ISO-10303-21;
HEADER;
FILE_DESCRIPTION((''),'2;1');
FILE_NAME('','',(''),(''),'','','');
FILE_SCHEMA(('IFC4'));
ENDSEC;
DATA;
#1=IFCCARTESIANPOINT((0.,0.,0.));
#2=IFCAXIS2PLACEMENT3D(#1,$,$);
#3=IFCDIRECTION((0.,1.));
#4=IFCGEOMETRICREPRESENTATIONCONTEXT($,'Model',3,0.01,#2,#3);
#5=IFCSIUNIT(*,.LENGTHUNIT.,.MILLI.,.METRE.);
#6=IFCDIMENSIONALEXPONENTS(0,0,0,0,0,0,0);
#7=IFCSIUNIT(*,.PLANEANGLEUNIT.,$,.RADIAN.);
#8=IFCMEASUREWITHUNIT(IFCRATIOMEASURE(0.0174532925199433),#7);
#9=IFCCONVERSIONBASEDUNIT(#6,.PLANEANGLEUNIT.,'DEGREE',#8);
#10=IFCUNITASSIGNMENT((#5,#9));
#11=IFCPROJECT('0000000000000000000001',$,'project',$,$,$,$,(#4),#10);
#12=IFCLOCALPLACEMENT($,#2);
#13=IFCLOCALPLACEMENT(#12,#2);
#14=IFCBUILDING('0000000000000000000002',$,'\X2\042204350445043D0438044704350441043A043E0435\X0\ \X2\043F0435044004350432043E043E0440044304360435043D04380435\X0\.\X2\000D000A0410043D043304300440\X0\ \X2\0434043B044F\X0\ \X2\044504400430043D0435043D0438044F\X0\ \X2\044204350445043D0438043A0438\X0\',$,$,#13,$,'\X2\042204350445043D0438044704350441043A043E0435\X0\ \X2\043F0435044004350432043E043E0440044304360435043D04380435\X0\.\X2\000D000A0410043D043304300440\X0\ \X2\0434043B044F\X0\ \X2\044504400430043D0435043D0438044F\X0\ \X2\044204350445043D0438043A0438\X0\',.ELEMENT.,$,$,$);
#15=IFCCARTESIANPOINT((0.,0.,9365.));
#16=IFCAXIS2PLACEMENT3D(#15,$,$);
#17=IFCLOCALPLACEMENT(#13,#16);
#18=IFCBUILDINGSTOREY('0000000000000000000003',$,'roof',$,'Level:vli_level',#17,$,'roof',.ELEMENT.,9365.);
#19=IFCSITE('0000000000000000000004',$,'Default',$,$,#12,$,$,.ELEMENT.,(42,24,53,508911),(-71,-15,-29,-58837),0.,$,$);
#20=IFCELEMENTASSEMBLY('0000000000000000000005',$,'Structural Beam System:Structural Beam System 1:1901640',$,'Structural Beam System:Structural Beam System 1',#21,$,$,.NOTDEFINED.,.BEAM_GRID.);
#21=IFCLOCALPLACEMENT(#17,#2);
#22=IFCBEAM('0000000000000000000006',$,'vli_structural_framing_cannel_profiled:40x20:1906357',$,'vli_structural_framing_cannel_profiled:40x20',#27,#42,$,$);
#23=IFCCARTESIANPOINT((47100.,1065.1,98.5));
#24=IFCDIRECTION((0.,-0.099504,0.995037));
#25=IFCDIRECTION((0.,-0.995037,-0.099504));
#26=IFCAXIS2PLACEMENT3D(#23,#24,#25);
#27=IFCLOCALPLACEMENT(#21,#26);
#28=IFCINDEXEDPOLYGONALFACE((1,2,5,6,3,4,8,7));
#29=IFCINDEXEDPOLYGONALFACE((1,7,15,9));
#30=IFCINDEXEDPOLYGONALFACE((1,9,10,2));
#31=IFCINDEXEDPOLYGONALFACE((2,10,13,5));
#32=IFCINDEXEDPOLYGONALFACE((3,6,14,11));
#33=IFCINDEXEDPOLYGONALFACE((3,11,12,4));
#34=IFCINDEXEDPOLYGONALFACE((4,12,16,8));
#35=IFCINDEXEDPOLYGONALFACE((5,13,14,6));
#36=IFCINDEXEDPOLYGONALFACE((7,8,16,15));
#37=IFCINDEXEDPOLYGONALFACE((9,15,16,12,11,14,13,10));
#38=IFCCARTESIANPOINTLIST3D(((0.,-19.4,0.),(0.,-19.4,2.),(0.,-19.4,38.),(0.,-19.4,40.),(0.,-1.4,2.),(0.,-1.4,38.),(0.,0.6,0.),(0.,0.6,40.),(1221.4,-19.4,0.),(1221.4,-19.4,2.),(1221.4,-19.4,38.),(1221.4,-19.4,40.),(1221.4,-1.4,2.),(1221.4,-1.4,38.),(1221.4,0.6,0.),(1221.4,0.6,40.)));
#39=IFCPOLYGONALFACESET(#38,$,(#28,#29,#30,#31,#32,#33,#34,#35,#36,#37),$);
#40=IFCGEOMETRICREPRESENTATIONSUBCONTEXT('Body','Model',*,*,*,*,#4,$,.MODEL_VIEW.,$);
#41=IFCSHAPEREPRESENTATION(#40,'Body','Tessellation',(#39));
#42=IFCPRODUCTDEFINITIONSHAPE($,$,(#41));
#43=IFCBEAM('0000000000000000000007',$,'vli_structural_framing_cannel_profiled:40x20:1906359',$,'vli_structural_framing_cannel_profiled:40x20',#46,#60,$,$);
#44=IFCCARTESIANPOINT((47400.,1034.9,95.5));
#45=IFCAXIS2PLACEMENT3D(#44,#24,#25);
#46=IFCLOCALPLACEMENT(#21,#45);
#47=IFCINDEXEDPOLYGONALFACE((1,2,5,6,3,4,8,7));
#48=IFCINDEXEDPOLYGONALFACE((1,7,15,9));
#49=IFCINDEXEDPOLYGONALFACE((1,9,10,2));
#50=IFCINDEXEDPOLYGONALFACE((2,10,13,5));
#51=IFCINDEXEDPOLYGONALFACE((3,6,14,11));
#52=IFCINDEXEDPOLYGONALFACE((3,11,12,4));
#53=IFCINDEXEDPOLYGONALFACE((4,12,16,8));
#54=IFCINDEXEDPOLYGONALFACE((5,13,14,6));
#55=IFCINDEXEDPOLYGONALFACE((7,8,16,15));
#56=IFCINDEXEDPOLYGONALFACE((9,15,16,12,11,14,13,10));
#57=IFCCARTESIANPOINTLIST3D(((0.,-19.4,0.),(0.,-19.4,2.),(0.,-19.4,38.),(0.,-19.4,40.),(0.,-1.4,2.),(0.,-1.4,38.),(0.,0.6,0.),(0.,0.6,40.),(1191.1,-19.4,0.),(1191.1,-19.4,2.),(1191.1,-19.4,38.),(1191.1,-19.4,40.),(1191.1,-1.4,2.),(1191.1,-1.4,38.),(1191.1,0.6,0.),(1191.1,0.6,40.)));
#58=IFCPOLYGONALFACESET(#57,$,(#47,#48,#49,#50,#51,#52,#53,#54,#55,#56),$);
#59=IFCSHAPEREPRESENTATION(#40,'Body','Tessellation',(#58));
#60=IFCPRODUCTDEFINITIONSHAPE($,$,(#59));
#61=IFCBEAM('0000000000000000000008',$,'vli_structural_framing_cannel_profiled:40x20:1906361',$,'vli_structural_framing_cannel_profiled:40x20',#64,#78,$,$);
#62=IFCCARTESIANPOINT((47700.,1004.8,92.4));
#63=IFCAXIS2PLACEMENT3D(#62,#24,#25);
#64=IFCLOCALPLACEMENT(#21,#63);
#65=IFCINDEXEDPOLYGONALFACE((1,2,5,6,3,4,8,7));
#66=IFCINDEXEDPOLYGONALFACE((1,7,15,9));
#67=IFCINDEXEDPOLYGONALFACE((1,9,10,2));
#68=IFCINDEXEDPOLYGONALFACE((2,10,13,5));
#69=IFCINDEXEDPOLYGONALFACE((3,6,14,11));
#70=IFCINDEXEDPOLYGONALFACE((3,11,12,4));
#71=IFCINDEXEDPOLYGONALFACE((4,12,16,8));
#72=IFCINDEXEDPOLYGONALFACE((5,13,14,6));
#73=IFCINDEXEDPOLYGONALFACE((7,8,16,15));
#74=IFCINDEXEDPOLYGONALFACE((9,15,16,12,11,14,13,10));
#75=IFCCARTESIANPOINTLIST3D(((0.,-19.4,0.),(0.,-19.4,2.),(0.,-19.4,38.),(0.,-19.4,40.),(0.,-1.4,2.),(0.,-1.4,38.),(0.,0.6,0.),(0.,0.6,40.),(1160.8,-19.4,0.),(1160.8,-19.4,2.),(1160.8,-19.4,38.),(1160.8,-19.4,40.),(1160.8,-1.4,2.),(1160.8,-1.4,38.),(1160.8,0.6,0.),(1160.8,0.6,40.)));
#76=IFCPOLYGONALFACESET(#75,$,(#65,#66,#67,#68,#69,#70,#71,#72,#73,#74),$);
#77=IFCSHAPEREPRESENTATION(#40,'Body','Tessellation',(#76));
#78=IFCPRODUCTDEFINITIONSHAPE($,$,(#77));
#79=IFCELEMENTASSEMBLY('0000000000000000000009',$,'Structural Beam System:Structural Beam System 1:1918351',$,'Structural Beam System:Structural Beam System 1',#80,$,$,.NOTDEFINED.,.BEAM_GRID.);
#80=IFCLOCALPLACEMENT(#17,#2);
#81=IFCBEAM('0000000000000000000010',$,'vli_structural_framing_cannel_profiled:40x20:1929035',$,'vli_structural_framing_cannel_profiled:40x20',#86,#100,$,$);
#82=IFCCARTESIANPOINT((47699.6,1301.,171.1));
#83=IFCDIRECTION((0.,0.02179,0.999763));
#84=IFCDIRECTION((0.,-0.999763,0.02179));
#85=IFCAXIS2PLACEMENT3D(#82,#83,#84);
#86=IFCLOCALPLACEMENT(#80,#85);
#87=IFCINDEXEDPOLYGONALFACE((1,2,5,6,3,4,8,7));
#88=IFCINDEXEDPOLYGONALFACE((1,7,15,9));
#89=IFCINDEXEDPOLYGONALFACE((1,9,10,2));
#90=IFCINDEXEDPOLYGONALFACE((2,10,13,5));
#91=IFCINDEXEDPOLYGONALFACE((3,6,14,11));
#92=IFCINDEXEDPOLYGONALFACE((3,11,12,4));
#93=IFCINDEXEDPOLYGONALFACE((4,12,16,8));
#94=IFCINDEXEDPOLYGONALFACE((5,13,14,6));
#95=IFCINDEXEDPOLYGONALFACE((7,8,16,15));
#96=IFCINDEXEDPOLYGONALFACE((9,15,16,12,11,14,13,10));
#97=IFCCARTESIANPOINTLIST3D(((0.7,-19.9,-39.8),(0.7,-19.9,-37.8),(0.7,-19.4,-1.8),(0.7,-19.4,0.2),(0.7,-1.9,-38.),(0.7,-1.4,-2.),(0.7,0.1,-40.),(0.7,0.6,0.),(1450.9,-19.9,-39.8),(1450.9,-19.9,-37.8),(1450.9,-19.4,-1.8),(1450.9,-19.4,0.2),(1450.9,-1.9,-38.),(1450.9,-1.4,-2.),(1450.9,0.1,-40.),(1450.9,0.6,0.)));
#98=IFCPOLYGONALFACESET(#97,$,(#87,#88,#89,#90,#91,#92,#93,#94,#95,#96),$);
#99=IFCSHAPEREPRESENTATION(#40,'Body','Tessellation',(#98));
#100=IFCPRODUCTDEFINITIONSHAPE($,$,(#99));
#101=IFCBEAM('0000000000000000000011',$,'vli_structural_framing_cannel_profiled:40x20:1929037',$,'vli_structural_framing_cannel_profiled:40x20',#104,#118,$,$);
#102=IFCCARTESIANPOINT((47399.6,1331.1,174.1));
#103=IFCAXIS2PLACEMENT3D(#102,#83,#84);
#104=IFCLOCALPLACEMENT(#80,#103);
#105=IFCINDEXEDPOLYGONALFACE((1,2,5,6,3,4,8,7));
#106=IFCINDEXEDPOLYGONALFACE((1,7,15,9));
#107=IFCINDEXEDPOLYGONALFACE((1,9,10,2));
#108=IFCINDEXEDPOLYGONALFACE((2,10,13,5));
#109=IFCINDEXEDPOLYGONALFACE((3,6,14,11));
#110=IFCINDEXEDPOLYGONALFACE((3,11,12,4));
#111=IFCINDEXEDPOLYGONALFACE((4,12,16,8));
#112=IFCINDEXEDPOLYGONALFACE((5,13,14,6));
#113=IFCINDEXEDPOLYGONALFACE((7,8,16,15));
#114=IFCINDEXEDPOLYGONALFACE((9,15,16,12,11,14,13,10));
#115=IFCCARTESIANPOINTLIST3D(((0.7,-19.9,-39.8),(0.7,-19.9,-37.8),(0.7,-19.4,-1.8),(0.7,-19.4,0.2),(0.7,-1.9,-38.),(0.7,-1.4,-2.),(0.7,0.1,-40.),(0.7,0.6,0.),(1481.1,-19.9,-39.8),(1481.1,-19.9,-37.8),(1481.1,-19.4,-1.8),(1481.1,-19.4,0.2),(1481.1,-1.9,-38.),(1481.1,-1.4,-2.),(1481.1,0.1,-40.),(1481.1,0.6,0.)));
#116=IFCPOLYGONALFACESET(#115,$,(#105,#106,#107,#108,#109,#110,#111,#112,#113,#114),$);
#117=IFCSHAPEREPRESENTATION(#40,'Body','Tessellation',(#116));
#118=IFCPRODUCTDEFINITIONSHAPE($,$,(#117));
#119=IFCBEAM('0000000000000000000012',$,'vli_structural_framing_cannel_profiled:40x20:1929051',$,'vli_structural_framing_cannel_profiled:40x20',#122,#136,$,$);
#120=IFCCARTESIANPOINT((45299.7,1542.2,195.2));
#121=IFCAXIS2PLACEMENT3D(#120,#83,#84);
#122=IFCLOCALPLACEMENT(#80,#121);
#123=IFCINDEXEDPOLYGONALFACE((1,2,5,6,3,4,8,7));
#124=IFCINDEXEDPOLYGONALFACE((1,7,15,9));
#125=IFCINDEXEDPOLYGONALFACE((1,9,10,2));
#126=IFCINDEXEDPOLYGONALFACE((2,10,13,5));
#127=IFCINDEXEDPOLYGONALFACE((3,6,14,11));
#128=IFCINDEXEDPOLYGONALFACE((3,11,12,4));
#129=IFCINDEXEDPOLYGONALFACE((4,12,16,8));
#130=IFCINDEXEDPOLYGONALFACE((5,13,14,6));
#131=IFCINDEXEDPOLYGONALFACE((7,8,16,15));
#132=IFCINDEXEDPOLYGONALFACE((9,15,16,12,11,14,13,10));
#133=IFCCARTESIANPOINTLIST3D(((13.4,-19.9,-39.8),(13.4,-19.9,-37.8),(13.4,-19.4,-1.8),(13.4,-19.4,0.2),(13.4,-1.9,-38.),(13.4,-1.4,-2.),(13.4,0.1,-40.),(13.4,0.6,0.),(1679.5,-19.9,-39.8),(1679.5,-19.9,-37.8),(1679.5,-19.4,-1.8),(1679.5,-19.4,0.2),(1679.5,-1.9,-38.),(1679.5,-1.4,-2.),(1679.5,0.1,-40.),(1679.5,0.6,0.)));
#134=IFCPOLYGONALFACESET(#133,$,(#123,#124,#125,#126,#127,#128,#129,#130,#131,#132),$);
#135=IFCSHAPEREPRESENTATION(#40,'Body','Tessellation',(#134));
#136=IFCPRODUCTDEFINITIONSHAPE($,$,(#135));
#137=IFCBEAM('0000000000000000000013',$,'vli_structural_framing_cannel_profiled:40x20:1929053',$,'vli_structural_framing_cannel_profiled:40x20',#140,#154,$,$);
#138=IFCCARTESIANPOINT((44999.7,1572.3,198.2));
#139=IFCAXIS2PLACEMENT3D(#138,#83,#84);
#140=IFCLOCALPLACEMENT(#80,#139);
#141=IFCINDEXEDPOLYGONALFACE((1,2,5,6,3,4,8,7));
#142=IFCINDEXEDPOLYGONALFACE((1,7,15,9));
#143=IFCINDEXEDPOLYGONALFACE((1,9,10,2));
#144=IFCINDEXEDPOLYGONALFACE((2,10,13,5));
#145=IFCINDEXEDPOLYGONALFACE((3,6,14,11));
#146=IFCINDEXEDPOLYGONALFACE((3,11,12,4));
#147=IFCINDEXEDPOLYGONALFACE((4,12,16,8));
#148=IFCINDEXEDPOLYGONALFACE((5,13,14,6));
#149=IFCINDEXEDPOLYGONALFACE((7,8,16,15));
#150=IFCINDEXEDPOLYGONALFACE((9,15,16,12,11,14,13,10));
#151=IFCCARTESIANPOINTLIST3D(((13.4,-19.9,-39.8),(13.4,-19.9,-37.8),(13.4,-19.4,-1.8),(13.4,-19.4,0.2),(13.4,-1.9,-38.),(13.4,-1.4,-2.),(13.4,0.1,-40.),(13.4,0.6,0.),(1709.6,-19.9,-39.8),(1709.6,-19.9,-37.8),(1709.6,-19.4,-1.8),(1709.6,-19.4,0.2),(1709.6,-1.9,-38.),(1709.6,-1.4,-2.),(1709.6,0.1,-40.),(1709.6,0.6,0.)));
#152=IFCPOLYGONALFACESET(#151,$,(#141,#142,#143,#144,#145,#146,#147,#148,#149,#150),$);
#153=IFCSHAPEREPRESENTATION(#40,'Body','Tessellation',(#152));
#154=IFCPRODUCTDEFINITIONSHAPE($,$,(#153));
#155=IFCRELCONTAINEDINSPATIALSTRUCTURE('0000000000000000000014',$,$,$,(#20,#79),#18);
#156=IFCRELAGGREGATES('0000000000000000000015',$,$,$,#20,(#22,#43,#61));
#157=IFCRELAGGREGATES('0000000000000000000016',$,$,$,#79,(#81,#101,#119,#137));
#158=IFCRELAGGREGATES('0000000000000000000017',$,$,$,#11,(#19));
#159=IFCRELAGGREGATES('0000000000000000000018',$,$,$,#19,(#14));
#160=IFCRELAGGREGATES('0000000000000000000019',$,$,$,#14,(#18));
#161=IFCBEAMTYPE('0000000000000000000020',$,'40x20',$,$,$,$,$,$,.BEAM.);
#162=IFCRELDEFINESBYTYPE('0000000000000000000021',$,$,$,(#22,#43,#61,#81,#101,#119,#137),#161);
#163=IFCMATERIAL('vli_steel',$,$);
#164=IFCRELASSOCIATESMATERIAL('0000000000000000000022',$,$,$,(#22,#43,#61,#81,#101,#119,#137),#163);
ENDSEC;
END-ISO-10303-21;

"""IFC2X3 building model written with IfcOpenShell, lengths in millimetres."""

from ifc_helpers import new_model, entity, si_unit, converted_unit, direction, frame, origin, place, context, subcontext, project, spatial, polyline, outline, extrude, material, type_object, element, aggregate, save


model = new_model("IFC2X3")

# Units and contexts
model_context = context("Model", 3, precision=0.01, world=origin(), true_north=direction((0.0, 1.0)))
body_context = subcontext(model_context, "Body", "Model", "MODEL_VIEW")
ifc_project = project(units=[si_unit("LENGTHUNIT", "METRE", prefix="MILLI"), converted_unit("PLANEANGLEUNIT", "DEGREE", entity("IfcRatioMeasure", 0.0174532925199433), si_unit("PLANEANGLEUNIT", "RADIAN"), dimensions=[0, 0, 0, 0, 0, 0, 0])], contexts=[model_context])

# Site, building, storey
site_placement = place(None, origin())
site = spatial("IfcSite", under=ifc_project, at=site_placement, Name="Default", CompositionType="ELEMENT", RefLatitude=(42, 24, 53, 508911), RefLongitude=(-71, -15, -29, -58837), RefElevation=0.0)
building_placement = place(site_placement, origin())
building = spatial("IfcBuilding", under=site, at=building_placement, Name="Техническое перевооружение.\r\nАнгар для хранения техники", LongName="Техническое перевооружение.\r\nАнгар для хранения техники", CompositionType="ELEMENT")
storey_placement = place(building_placement, frame((0.0, 0.0, 9365.0)))
storey = spatial("IfcBuildingStorey", under=building, at=storey_placement, Name="roof", ObjectType="Level:vli_level", LongName="roof", CompositionType="ELEMENT", Elevation=9365.0)

# Element assemblies, beams
assembly_1_placement = place(storey_placement, origin())
assembly_1 = element("IfcElementAssembly", 1, at=assembly_1_placement, inside=storey, Name="Structural Beam System:Structural Beam System 1:1901640", ObjectType="Structural Beam System:Structural Beam System 1", AssemblyPlace="NOTDEFINED", PredefinedType="BEAM_GRID")
ifc_material = material(Name="vli_steel")
beam_type = type_object("IfcBeamType", Name="40x20", PredefinedType="BEAM")
beam_1_placement = place(assembly_1_placement, frame((47100.0, 1065.1, 98.5), z_axis=(0.0, -0.099504, 0.995037), x_axis=(0.0, -0.995037, -0.099504)))
beam_1 = element("IfcBeam", 2, at=beam_1_placement, type_object=beam_type, material=ifc_material, Name="vli_structural_framing_cannel_profiled:40x20:1906357", ObjectType="vli_structural_framing_cannel_profiled:40x20", context=body_context, shape_type="SweptSolid", body=[
    extrude(outline(polyline([(-20.0, -9.5), (-18.0, -9.5), (-18.0, 8.5), (18.0, 8.5), (18.0, -9.5), (20.0, -9.5), (20.0, 10.5), (-20.0, 10.5), (-20.0, -9.5)])), frame((0.0, -9.9, 20.0), z_axis=(1.0, 0.0, 0.0), x_axis=(0.0, 0.0, -1.0)), (0.0, 0.0, 1.0), 1221.4),
])
beam_2_placement = place(assembly_1_placement, frame((47400.0, 1034.9, 95.5), z_axis=(0.0, -0.099504, 0.995037), x_axis=(0.0, -0.995037, -0.099504)))
beam_2 = element("IfcBeam", 3, at=beam_2_placement, type_object=beam_type, material=ifc_material, Name="vli_structural_framing_cannel_profiled:40x20:1906359", ObjectType="vli_structural_framing_cannel_profiled:40x20", context=body_context, shape_type="SweptSolid", body=[
    extrude(outline(polyline([(-20.0, -9.5), (-18.0, -9.5), (-18.0, 8.5), (18.0, 8.5), (18.0, -9.5), (20.0, -9.5), (20.0, 10.5), (-20.0, 10.5), (-20.0, -9.5)])), frame((0.0, -9.9, 20.0), z_axis=(1.0, 0.0, 0.0), x_axis=(0.0, 0.0, -1.0)), (0.0, 0.0, 1.0), 1191.1),
])
beam_3_placement = place(assembly_1_placement, frame((47700.0, 1004.8, 92.4), z_axis=(0.0, -0.099504, 0.995037), x_axis=(0.0, -0.995037, -0.099504)))
beam_3 = element("IfcBeam", 4, at=beam_3_placement, type_object=beam_type, material=ifc_material, Name="vli_structural_framing_cannel_profiled:40x20:1906361", ObjectType="vli_structural_framing_cannel_profiled:40x20", context=body_context, shape_type="SweptSolid", body=[
    extrude(outline(polyline([(-20.0, -9.5), (-18.0, -9.5), (-18.0, 8.5), (18.0, 8.5), (18.0, -9.5), (20.0, -9.5), (20.0, 10.5), (-20.0, 10.5), (-20.0, -9.5)])), frame((0.0, -9.9, 20.0), z_axis=(1.0, 0.0, 0.0), x_axis=(0.0, 0.0, -1.0)), (0.0, 0.0, 1.0), 1160.8),
])
aggregate(assembly_1, [beam_1, beam_2, beam_3])
assembly_2_placement = place(storey_placement, origin())
assembly_2 = element("IfcElementAssembly", 5, at=assembly_2_placement, inside=storey, Name="Structural Beam System:Structural Beam System 1:1918351", ObjectType="Structural Beam System:Structural Beam System 1", AssemblyPlace="NOTDEFINED", PredefinedType="BEAM_GRID")
beam_4_placement = place(assembly_2_placement, frame((47699.6, 1301.0, 171.1), z_axis=(0.0, 0.02179, 0.999763), x_axis=(0.0, -0.999763, 0.02179)))
beam_4 = element("IfcBeam", 6, at=beam_4_placement, type_object=beam_type, material=ifc_material, Name="vli_structural_framing_cannel_profiled:40x20:1929035", ObjectType="vli_structural_framing_cannel_profiled:40x20", context=body_context, shape_type="SweptSolid", body=[
    extrude(outline(polyline([(-10.5, -20.0), (9.5, -20.0), (9.5, -18.0), (-8.5, -18.0), (-8.5, 18.0), (9.5, 18.0), (9.5, 20.0), (-10.5, 20.0), (-10.5, -20.0)])), frame((0.7, -10.1, -19.9), z_axis=(1.0, 0.0, 0.0), x_axis=(0.0, -0.999925, 0.012243)), (0.0, 0.0, 1.0), 1450.2),
])
beam_5_placement = place(assembly_2_placement, frame((47399.6, 1331.1, 174.1), z_axis=(0.0, 0.02179, 0.999763), x_axis=(0.0, -0.999763, 0.02179)))
beam_5 = element("IfcBeam", 7, at=beam_5_placement, type_object=beam_type, material=ifc_material, Name="vli_structural_framing_cannel_profiled:40x20:1929037", ObjectType="vli_structural_framing_cannel_profiled:40x20", context=body_context, shape_type="SweptSolid", body=[
    extrude(outline(polyline([(-10.5, -20.0), (9.5, -20.0), (9.5, -18.0), (-8.5, -18.0), (-8.5, 18.0), (9.5, 18.0), (9.5, 20.0), (-10.5, 20.0), (-10.5, -20.0)])), frame((0.7, -10.1, -19.9), z_axis=(1.0, 0.0, 0.0), x_axis=(0.0, -0.999925, 0.012243)), (0.0, 0.0, 1.0), 1480.4),
])
beam_6_placement = place(assembly_2_placement, frame((45299.7, 1542.2, 195.2), z_axis=(0.0, 0.02179, 0.999763), x_axis=(0.0, -0.999763, 0.02179)))
beam_6 = element("IfcBeam", 8, at=beam_6_placement, type_object=beam_type, material=ifc_material, Name="vli_structural_framing_cannel_profiled:40x20:1929051", ObjectType="vli_structural_framing_cannel_profiled:40x20", context=body_context, shape_type="SweptSolid", body=[
    extrude(outline(polyline([(-10.5, -20.0), (9.5, -20.0), (9.5, -18.0), (-8.5, -18.0), (-8.5, 18.0), (9.5, 18.0), (9.5, 20.0), (-10.5, 20.0), (-10.5, -20.0)])), frame((13.4, -10.1, -19.9), z_axis=(1.0, 0.0, 0.0), x_axis=(0.0, -0.999925, 0.012243)), (0.0, 0.0, 1.0), 1666.1),
])
beam_7_placement = place(assembly_2_placement, frame((44999.7, 1572.3, 198.2), z_axis=(0.0, 0.02179, 0.999763), x_axis=(0.0, -0.999763, 0.02179)))
beam_7 = element("IfcBeam", 9, at=beam_7_placement, type_object=beam_type, material=ifc_material, Name="vli_structural_framing_cannel_profiled:40x20:1929053", ObjectType="vli_structural_framing_cannel_profiled:40x20", context=body_context, shape_type="SweptSolid", body=[
    extrude(outline(polyline([(-10.5, -20.0), (9.5, -20.0), (9.5, -18.0), (-8.5, -18.0), (-8.5, 18.0), (9.5, 18.0), (9.5, 20.0), (-10.5, 20.0), (-10.5, -20.0)])), frame((13.4, -10.1, -19.9), z_axis=(1.0, 0.0, 0.0), x_axis=(0.0, -0.999925, 0.012243)), (0.0, 0.0, 1.0), 1696.3),
])
aggregate(assembly_2, [beam_4, beam_5, beam_6, beam_7])

save(model, "model.ifc")
